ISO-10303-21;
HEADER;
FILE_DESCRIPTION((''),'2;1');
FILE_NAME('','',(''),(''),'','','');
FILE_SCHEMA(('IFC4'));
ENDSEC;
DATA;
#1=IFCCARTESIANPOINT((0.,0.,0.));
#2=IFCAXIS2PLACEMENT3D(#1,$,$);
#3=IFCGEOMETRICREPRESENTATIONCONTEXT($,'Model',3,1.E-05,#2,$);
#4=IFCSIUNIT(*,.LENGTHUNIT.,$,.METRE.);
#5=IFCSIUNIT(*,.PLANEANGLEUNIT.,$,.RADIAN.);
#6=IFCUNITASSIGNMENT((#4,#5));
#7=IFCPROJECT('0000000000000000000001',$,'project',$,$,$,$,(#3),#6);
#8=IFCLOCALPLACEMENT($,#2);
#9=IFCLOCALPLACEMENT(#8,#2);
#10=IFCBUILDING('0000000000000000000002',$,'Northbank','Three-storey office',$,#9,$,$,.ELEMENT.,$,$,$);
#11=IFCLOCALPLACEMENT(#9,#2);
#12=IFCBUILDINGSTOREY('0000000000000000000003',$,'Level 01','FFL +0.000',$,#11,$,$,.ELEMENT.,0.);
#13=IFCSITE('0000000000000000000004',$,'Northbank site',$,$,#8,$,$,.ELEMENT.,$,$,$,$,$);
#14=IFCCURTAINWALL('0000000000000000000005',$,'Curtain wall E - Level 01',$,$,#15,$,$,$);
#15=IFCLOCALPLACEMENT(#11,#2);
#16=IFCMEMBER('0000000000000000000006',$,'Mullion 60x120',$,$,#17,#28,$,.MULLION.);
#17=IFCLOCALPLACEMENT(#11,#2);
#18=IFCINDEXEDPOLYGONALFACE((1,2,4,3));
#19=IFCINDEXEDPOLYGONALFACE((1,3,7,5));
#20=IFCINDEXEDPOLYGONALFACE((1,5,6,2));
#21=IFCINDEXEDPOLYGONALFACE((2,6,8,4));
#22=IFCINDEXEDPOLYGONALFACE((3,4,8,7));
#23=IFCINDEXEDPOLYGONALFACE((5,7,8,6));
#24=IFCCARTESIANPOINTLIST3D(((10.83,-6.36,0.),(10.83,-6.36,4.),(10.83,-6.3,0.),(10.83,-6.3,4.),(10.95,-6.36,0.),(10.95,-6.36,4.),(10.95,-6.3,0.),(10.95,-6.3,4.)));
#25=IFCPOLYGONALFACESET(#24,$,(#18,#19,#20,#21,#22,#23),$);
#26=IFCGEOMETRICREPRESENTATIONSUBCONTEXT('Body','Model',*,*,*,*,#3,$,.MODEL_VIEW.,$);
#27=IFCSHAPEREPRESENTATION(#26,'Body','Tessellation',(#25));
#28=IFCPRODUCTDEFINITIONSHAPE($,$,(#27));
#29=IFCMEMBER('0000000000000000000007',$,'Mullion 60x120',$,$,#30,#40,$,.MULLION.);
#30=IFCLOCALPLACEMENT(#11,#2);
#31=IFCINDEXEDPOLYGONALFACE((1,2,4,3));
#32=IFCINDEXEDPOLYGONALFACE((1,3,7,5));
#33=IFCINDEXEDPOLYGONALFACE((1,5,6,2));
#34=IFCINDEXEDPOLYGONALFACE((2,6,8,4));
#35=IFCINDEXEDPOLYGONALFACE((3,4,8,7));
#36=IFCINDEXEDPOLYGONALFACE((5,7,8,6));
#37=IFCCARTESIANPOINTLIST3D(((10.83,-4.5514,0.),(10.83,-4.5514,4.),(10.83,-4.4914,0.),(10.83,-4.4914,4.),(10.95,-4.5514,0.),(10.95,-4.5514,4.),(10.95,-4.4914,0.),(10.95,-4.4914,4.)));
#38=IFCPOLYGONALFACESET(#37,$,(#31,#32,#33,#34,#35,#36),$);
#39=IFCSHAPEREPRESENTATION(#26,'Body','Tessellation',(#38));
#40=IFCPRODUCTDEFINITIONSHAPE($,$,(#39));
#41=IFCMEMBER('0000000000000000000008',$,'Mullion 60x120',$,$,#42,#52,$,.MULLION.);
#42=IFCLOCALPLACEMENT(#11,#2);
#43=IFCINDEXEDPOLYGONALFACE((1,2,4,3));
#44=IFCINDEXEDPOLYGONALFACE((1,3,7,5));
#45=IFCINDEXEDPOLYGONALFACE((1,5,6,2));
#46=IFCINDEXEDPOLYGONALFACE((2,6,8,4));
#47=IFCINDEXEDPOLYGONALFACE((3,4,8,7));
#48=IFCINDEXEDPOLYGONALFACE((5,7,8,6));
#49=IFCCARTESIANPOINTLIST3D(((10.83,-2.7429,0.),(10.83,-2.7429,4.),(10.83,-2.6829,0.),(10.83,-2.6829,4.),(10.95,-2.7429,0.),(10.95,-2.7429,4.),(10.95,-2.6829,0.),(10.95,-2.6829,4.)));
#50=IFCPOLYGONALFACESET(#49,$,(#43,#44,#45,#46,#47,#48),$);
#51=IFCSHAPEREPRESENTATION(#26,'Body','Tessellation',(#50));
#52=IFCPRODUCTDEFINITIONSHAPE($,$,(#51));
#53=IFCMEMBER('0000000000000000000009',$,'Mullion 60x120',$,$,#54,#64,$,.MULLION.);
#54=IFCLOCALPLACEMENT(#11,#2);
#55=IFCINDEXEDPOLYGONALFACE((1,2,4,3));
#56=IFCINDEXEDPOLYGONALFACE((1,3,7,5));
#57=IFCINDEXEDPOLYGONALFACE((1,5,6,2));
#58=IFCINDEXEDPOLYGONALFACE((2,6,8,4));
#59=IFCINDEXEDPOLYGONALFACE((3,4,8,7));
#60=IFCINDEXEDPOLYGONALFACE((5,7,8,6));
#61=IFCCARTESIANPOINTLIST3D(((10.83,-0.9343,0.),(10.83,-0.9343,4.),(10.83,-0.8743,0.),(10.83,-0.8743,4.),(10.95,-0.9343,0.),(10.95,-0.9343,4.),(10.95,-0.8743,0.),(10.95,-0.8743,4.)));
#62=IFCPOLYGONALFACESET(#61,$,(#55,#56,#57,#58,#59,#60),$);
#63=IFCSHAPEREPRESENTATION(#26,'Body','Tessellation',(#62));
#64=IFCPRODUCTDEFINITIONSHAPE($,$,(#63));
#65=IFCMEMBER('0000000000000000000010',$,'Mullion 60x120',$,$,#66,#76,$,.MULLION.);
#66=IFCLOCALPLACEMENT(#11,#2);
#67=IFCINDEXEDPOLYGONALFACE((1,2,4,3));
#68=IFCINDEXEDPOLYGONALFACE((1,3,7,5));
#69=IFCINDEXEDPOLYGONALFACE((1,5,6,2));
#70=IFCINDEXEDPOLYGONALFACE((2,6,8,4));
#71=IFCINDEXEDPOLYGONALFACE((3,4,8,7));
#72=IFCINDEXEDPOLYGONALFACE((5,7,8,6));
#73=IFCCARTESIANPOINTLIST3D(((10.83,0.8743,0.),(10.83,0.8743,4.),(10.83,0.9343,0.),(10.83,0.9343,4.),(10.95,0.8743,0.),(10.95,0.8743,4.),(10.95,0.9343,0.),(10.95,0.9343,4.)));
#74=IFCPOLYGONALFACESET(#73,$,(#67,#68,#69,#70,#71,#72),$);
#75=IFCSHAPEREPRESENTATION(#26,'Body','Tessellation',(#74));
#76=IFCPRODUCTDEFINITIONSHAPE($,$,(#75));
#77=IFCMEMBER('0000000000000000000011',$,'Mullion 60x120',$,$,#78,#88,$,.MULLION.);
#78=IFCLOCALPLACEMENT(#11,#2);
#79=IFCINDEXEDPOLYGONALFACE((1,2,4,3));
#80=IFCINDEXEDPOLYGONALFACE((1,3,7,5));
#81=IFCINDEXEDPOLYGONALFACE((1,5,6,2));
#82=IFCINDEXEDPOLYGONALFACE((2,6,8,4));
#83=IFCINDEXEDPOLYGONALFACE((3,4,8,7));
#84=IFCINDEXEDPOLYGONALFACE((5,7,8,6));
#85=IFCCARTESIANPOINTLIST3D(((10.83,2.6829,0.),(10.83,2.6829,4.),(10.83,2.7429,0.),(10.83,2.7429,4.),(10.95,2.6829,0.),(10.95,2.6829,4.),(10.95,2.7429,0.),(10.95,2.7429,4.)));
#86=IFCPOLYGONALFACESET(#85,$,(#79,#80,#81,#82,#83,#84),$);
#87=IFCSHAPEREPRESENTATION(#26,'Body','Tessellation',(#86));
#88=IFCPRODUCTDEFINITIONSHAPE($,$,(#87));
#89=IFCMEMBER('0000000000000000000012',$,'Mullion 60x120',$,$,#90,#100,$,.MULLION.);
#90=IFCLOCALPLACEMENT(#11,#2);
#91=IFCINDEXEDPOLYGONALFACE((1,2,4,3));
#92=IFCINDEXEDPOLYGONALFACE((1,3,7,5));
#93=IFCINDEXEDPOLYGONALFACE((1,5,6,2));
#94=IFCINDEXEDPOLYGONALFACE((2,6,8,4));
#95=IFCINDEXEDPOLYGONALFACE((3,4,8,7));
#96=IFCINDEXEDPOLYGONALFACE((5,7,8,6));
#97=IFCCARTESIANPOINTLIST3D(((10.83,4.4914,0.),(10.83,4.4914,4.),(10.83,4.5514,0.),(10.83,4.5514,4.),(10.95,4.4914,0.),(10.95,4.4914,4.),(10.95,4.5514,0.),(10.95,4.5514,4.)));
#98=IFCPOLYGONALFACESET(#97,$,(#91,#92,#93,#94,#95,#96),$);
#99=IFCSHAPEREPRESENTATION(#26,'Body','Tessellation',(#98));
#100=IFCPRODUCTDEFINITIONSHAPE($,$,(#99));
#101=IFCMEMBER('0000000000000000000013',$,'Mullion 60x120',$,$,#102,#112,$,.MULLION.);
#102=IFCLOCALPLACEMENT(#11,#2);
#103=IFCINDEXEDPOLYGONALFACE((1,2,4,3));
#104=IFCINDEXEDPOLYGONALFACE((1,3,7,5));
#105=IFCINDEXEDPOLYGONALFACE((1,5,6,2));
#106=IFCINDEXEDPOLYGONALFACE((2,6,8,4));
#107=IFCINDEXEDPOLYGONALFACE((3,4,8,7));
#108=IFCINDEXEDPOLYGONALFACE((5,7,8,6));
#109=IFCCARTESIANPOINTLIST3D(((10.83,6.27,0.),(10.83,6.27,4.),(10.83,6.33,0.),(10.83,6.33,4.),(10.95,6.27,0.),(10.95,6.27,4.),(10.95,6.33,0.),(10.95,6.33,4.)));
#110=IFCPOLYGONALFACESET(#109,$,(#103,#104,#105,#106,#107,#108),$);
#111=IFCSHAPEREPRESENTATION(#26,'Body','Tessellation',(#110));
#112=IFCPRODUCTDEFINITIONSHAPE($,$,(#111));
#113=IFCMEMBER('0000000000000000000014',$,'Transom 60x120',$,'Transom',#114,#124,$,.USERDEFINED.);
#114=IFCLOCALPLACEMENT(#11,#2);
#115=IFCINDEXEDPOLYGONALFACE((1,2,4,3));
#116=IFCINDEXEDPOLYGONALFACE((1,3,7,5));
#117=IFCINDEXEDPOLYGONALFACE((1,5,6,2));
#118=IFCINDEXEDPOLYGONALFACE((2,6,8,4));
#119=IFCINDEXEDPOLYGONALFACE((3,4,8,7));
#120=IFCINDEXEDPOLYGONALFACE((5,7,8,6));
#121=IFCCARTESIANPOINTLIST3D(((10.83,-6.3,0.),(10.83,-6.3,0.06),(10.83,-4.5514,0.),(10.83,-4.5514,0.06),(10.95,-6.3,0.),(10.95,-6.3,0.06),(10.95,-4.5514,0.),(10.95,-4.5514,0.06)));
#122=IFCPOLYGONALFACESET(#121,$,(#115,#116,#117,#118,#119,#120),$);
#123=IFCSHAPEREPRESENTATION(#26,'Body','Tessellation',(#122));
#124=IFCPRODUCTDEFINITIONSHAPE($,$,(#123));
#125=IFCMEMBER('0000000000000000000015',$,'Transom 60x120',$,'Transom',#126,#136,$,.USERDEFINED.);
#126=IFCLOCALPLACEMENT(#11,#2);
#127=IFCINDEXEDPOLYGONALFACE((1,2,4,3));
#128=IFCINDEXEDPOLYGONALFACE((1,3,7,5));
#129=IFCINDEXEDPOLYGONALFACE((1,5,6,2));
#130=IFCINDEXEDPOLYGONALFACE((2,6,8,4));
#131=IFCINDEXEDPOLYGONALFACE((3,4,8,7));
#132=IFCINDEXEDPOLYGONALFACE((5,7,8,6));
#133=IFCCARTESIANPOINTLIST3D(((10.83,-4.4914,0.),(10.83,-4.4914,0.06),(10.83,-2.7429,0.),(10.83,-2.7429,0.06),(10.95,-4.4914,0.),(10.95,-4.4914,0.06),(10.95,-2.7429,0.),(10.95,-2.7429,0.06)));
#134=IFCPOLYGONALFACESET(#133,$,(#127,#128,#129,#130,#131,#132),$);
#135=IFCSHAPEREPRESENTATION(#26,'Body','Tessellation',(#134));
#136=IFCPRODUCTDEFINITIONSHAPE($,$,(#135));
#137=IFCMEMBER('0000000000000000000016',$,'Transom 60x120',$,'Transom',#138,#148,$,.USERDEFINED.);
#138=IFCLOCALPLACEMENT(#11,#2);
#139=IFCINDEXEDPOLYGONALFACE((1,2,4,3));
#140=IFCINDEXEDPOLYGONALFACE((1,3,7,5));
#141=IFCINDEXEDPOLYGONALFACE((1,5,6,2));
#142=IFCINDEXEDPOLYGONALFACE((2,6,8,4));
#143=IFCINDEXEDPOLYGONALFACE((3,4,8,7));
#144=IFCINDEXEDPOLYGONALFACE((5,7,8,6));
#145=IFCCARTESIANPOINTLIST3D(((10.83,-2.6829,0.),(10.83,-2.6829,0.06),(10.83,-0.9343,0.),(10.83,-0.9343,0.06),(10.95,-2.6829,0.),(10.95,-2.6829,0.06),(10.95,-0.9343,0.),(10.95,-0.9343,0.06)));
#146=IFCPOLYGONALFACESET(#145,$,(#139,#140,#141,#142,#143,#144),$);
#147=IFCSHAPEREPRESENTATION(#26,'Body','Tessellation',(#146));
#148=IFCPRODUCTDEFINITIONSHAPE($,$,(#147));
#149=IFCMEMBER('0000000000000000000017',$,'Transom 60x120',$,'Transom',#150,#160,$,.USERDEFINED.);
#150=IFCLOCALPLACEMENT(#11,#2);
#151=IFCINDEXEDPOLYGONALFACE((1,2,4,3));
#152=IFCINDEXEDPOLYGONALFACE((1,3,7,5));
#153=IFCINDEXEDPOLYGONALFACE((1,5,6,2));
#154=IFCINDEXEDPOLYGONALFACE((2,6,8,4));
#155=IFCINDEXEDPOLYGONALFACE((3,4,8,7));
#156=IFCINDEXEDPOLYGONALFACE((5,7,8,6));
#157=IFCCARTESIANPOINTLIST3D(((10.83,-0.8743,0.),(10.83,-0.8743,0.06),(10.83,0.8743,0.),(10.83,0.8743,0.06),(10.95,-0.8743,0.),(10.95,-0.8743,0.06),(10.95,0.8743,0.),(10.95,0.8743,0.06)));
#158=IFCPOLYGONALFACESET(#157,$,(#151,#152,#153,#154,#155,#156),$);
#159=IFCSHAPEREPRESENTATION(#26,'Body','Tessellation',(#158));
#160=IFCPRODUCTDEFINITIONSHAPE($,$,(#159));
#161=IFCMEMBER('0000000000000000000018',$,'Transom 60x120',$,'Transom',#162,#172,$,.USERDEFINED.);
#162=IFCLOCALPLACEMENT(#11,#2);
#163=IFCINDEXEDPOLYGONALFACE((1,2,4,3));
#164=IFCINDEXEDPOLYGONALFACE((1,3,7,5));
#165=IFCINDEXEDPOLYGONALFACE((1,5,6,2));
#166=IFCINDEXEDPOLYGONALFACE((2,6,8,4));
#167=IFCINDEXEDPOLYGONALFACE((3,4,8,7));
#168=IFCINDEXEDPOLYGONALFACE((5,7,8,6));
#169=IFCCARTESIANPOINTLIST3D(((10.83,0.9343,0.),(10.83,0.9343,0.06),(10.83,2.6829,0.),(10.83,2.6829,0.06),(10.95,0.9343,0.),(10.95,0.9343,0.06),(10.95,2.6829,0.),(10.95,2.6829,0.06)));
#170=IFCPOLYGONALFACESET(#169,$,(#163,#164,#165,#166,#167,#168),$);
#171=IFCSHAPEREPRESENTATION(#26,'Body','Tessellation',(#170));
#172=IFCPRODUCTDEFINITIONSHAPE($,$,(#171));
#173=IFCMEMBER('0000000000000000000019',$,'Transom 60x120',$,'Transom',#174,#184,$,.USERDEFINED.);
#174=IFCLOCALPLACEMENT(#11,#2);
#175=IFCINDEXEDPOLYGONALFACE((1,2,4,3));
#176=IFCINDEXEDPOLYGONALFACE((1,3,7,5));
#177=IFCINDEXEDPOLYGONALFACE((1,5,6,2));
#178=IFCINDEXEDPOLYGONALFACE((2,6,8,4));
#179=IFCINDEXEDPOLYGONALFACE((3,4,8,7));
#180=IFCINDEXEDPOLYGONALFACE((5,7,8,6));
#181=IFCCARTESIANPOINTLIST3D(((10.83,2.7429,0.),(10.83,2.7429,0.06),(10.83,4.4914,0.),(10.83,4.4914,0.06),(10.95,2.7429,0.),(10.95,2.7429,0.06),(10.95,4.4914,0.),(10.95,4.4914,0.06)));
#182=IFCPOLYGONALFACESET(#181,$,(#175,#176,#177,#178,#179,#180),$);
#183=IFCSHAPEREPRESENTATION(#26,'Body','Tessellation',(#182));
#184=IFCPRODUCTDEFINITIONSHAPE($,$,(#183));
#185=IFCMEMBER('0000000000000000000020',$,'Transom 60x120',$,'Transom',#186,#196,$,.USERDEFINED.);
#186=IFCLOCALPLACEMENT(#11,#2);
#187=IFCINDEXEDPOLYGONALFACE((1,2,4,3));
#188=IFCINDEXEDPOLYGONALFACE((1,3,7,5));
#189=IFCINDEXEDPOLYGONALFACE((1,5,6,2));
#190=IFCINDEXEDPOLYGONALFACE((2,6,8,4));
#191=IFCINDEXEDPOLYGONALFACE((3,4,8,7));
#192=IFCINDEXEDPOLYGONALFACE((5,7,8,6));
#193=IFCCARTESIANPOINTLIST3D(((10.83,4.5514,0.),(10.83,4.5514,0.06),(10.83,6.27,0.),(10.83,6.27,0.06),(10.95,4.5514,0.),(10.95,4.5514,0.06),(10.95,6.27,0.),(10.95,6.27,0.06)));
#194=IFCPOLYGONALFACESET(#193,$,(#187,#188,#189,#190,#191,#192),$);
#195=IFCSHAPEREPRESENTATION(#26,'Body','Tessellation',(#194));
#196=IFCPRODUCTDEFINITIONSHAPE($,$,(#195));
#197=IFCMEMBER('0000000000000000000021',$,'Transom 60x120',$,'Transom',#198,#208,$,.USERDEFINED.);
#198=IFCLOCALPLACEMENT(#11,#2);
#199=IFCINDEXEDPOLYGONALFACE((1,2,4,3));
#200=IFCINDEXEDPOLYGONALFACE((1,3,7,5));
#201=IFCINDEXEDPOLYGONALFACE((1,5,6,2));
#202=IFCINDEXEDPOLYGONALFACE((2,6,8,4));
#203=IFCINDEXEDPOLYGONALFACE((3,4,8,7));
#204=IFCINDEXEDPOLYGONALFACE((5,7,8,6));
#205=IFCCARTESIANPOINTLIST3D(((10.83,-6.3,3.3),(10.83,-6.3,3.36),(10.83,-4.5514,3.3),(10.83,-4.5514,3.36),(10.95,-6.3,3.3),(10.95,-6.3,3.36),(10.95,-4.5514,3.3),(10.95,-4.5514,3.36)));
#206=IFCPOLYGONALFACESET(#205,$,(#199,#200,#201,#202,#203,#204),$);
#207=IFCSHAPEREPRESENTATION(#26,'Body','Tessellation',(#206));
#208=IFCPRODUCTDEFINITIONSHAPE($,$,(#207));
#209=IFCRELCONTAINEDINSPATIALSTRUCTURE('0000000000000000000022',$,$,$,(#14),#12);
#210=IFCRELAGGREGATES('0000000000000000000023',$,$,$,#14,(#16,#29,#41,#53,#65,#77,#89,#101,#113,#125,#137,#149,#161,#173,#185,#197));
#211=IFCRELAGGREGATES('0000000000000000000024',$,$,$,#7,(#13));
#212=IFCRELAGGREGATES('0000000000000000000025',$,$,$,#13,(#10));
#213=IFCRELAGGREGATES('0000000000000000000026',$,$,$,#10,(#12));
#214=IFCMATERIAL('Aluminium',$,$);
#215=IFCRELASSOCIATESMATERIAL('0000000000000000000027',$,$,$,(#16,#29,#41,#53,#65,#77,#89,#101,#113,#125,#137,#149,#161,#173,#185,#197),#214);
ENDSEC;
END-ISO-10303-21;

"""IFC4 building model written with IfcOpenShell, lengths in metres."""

from ifc_helpers import new_model, si_unit, frame, origin, place, context, subcontext, project, spatial, rectangle, extrude, material, element, aggregate, save


model = new_model("IFC4")

# Units and contexts
model_context = context("Model", 3, precision=1e-05, world=origin())
body_context = subcontext(model_context, "Body", "Model", "MODEL_VIEW")
ifc_project = project(units=[si_unit("LENGTHUNIT", "METRE"), si_unit("PLANEANGLEUNIT", "RADIAN")], contexts=[model_context])

# Site, building, storey
site_placement = place(None, origin())
site = spatial("IfcSite", under=ifc_project, at=site_placement, Name="Northbank site", CompositionType="ELEMENT")
building_placement = place(site_placement, origin())
building = spatial("IfcBuilding", under=site, at=building_placement, Name="Northbank", Description="Three-storey office", CompositionType="ELEMENT")
storey_placement = place(building_placement, origin())
storey = spatial("IfcBuildingStorey", under=building, at=storey_placement, Name="Level 01", Description="FFL +0.000", CompositionType="ELEMENT", Elevation=0.0)

# Curtain wall, members
curtain_wall_1_placement = place(storey_placement, origin())
curtain_wall_1 = element("IfcCurtainWall", 1, at=curtain_wall_1_placement, inside=storey, Name="Curtain wall E - Level 01")
ifc_material_1 = material(Name="Aluminium")
member_1_placement = place(storey_placement, origin())
member_1 = element("IfcMember", 2, at=member_1_placement, material=ifc_material_1, Name="Mullion 60x120", PredefinedType="MULLION", context=body_context, shape_type="SweptSolid", body=[
    extrude(rectangle(XDim=0.12, YDim=0.06), frame((10.89, -6.33, 0.0)), (0.0, 0.0, 1.0), 4.0),
])
member_2_placement = place(storey_placement, origin())
member_2 = element("IfcMember", 3, at=member_2_placement, material=ifc_material_1, Name="Mullion 60x120", PredefinedType="MULLION", context=body_context, shape_type="SweptSolid", body=[
    extrude(rectangle(XDim=0.12, YDim=0.06), frame((10.89, -4.5214, 0.0)), (0.0, 0.0, 1.0), 4.0),
])
member_3_placement = place(storey_placement, origin())
member_3 = element("IfcMember", 4, at=member_3_placement, material=ifc_material_1, Name="Mullion 60x120", PredefinedType="MULLION", context=body_context, shape_type="SweptSolid", body=[
    extrude(rectangle(XDim=0.12, YDim=0.06), frame((10.89, -2.7129, 0.0)), (0.0, 0.0, 1.0), 4.0),
])
member_4_placement = place(storey_placement, origin())
member_4 = element("IfcMember", 5, at=member_4_placement, material=ifc_material_1, Name="Mullion 60x120", PredefinedType="MULLION", context=body_context, shape_type="SweptSolid", body=[
    extrude(rectangle(XDim=0.12, YDim=0.06), frame((10.89, -0.9043, 0.0)), (0.0, 0.0, 1.0), 4.0),
])
member_5_placement = place(storey_placement, origin())
member_5 = element("IfcMember", 6, at=member_5_placement, material=ifc_material_1, Name="Mullion 60x120", PredefinedType="MULLION", context=body_context, shape_type="SweptSolid", body=[
    extrude(rectangle(XDim=0.12, YDim=0.06), frame((10.89, 0.9043, 0.0)), (0.0, 0.0, 1.0), 4.0),
])
member_6_placement = place(storey_placement, origin())
member_6 = element("IfcMember", 7, at=member_6_placement, material=ifc_material_1, Name="Mullion 60x120", PredefinedType="MULLION", context=body_context, shape_type="SweptSolid", body=[
    extrude(rectangle(XDim=0.12, YDim=0.06), frame((10.89, 2.7129, 0.0)), (0.0, 0.0, 1.0), 4.0),
])
member_7_placement = place(storey_placement, origin())
member_7 = element("IfcMember", 8, at=member_7_placement, material=ifc_material_1, Name="Mullion 60x120", PredefinedType="MULLION", context=body_context, shape_type="SweptSolid", body=[
    extrude(rectangle(XDim=0.12, YDim=0.06), frame((10.89, 4.5214, 0.0)), (0.0, 0.0, 1.0), 4.0),
])
member_8_placement = place(storey_placement, origin())
member_8 = element("IfcMember", 9, at=member_8_placement, material=ifc_material_1, Name="Mullion 60x120", PredefinedType="MULLION", context=body_context, shape_type="SweptSolid", body=[
    extrude(rectangle(XDim=0.12, YDim=0.06), frame((10.89, 6.3, 0.0)), (0.0, 0.0, 1.0), 4.0),
])
member_9_placement = place(storey_placement, origin())
member_9 = element("IfcMember", 10, at=member_9_placement, material=ifc_material_1, Name="Transom 60x120", ObjectType="Transom", PredefinedType="USERDEFINED", context=body_context, shape_type="SweptSolid", body=[
    extrude(rectangle(XDim=0.12, YDim=1.7486), frame((10.89, -5.4257, 0.0)), (0.0, 0.0, 1.0), 0.06),
])
member_10_placement = place(storey_placement, origin())
member_10 = element("IfcMember", 11, at=member_10_placement, material=ifc_material_1, Name="Transom 60x120", ObjectType="Transom", PredefinedType="USERDEFINED", context=body_context, shape_type="SweptSolid", body=[
    extrude(rectangle(XDim=0.12, YDim=1.7486), frame((10.89, -3.6171, 0.0)), (0.0, 0.0, 1.0), 0.06),
])
member_11_placement = place(storey_placement, origin())
member_11 = element("IfcMember", 12, at=member_11_placement, material=ifc_material_1, Name="Transom 60x120", ObjectType="Transom", PredefinedType="USERDEFINED", context=body_context, shape_type="SweptSolid", body=[
    extrude(rectangle(XDim=0.12, YDim=1.7486), frame((10.89, -1.8086, 0.0)), (0.0, 0.0, 1.0), 0.06),
])
member_12_placement = place(storey_placement, origin())
member_12 = element("IfcMember", 13, at=member_12_placement, material=ifc_material_1, Name="Transom 60x120", ObjectType="Transom", PredefinedType="USERDEFINED", context=body_context, shape_type="SweptSolid", body=[
    extrude(rectangle(XDim=0.12, YDim=1.7486), frame((10.89, 0.0, 0.0)), (0.0, 0.0, 1.0), 0.06),
])
member_13_placement = place(storey_placement, origin())
member_13 = element("IfcMember", 14, at=member_13_placement, material=ifc_material_1, Name="Transom 60x120", ObjectType="Transom", PredefinedType="USERDEFINED", context=body_context, shape_type="SweptSolid", body=[
    extrude(rectangle(XDim=0.12, YDim=1.7486), frame((10.89, 1.8086, 0.0)), (0.0, 0.0, 1.0), 0.06),
])
member_14_placement = place(storey_placement, origin())
member_14 = element("IfcMember", 15, at=member_14_placement, material=ifc_material_1, Name="Transom 60x120", ObjectType="Transom", PredefinedType="USERDEFINED", context=body_context, shape_type="SweptSolid", body=[
    extrude(rectangle(XDim=0.12, YDim=1.7486), frame((10.89, 3.6171, 0.0)), (0.0, 0.0, 1.0), 0.06),
])
member_15_placement = place(storey_placement, origin())
member_15 = element("IfcMember", 16, at=member_15_placement, material=ifc_material_1, Name="Transom 60x120", ObjectType="Transom", PredefinedType="USERDEFINED", context=body_context, shape_type="SweptSolid", body=[
    extrude(rectangle(XDim=0.12, YDim=1.7186), frame((10.89, 5.4107, 0.0)), (0.0, 0.0, 1.0), 0.06),
])
member_16_placement = place(storey_placement, origin())
member_16 = element("IfcMember", 17, at=member_16_placement, material=ifc_material_1, Name="Transom 60x120", ObjectType="Transom", PredefinedType="USERDEFINED", context=body_context, shape_type="SweptSolid", body=[
    extrude(rectangle(XDim=0.12, YDim=1.7486), frame((10.89, -5.4257, 3.3)), (0.0, 0.0, 1.0), 0.06),
])
aggregate(curtain_wall_1, [member_1, member_2, member_3, member_4, member_5, member_6, member_7, member_8, member_9, member_10, member_11, member_12, member_13, member_14, member_15, member_16])

save(model, "model.ifc")
